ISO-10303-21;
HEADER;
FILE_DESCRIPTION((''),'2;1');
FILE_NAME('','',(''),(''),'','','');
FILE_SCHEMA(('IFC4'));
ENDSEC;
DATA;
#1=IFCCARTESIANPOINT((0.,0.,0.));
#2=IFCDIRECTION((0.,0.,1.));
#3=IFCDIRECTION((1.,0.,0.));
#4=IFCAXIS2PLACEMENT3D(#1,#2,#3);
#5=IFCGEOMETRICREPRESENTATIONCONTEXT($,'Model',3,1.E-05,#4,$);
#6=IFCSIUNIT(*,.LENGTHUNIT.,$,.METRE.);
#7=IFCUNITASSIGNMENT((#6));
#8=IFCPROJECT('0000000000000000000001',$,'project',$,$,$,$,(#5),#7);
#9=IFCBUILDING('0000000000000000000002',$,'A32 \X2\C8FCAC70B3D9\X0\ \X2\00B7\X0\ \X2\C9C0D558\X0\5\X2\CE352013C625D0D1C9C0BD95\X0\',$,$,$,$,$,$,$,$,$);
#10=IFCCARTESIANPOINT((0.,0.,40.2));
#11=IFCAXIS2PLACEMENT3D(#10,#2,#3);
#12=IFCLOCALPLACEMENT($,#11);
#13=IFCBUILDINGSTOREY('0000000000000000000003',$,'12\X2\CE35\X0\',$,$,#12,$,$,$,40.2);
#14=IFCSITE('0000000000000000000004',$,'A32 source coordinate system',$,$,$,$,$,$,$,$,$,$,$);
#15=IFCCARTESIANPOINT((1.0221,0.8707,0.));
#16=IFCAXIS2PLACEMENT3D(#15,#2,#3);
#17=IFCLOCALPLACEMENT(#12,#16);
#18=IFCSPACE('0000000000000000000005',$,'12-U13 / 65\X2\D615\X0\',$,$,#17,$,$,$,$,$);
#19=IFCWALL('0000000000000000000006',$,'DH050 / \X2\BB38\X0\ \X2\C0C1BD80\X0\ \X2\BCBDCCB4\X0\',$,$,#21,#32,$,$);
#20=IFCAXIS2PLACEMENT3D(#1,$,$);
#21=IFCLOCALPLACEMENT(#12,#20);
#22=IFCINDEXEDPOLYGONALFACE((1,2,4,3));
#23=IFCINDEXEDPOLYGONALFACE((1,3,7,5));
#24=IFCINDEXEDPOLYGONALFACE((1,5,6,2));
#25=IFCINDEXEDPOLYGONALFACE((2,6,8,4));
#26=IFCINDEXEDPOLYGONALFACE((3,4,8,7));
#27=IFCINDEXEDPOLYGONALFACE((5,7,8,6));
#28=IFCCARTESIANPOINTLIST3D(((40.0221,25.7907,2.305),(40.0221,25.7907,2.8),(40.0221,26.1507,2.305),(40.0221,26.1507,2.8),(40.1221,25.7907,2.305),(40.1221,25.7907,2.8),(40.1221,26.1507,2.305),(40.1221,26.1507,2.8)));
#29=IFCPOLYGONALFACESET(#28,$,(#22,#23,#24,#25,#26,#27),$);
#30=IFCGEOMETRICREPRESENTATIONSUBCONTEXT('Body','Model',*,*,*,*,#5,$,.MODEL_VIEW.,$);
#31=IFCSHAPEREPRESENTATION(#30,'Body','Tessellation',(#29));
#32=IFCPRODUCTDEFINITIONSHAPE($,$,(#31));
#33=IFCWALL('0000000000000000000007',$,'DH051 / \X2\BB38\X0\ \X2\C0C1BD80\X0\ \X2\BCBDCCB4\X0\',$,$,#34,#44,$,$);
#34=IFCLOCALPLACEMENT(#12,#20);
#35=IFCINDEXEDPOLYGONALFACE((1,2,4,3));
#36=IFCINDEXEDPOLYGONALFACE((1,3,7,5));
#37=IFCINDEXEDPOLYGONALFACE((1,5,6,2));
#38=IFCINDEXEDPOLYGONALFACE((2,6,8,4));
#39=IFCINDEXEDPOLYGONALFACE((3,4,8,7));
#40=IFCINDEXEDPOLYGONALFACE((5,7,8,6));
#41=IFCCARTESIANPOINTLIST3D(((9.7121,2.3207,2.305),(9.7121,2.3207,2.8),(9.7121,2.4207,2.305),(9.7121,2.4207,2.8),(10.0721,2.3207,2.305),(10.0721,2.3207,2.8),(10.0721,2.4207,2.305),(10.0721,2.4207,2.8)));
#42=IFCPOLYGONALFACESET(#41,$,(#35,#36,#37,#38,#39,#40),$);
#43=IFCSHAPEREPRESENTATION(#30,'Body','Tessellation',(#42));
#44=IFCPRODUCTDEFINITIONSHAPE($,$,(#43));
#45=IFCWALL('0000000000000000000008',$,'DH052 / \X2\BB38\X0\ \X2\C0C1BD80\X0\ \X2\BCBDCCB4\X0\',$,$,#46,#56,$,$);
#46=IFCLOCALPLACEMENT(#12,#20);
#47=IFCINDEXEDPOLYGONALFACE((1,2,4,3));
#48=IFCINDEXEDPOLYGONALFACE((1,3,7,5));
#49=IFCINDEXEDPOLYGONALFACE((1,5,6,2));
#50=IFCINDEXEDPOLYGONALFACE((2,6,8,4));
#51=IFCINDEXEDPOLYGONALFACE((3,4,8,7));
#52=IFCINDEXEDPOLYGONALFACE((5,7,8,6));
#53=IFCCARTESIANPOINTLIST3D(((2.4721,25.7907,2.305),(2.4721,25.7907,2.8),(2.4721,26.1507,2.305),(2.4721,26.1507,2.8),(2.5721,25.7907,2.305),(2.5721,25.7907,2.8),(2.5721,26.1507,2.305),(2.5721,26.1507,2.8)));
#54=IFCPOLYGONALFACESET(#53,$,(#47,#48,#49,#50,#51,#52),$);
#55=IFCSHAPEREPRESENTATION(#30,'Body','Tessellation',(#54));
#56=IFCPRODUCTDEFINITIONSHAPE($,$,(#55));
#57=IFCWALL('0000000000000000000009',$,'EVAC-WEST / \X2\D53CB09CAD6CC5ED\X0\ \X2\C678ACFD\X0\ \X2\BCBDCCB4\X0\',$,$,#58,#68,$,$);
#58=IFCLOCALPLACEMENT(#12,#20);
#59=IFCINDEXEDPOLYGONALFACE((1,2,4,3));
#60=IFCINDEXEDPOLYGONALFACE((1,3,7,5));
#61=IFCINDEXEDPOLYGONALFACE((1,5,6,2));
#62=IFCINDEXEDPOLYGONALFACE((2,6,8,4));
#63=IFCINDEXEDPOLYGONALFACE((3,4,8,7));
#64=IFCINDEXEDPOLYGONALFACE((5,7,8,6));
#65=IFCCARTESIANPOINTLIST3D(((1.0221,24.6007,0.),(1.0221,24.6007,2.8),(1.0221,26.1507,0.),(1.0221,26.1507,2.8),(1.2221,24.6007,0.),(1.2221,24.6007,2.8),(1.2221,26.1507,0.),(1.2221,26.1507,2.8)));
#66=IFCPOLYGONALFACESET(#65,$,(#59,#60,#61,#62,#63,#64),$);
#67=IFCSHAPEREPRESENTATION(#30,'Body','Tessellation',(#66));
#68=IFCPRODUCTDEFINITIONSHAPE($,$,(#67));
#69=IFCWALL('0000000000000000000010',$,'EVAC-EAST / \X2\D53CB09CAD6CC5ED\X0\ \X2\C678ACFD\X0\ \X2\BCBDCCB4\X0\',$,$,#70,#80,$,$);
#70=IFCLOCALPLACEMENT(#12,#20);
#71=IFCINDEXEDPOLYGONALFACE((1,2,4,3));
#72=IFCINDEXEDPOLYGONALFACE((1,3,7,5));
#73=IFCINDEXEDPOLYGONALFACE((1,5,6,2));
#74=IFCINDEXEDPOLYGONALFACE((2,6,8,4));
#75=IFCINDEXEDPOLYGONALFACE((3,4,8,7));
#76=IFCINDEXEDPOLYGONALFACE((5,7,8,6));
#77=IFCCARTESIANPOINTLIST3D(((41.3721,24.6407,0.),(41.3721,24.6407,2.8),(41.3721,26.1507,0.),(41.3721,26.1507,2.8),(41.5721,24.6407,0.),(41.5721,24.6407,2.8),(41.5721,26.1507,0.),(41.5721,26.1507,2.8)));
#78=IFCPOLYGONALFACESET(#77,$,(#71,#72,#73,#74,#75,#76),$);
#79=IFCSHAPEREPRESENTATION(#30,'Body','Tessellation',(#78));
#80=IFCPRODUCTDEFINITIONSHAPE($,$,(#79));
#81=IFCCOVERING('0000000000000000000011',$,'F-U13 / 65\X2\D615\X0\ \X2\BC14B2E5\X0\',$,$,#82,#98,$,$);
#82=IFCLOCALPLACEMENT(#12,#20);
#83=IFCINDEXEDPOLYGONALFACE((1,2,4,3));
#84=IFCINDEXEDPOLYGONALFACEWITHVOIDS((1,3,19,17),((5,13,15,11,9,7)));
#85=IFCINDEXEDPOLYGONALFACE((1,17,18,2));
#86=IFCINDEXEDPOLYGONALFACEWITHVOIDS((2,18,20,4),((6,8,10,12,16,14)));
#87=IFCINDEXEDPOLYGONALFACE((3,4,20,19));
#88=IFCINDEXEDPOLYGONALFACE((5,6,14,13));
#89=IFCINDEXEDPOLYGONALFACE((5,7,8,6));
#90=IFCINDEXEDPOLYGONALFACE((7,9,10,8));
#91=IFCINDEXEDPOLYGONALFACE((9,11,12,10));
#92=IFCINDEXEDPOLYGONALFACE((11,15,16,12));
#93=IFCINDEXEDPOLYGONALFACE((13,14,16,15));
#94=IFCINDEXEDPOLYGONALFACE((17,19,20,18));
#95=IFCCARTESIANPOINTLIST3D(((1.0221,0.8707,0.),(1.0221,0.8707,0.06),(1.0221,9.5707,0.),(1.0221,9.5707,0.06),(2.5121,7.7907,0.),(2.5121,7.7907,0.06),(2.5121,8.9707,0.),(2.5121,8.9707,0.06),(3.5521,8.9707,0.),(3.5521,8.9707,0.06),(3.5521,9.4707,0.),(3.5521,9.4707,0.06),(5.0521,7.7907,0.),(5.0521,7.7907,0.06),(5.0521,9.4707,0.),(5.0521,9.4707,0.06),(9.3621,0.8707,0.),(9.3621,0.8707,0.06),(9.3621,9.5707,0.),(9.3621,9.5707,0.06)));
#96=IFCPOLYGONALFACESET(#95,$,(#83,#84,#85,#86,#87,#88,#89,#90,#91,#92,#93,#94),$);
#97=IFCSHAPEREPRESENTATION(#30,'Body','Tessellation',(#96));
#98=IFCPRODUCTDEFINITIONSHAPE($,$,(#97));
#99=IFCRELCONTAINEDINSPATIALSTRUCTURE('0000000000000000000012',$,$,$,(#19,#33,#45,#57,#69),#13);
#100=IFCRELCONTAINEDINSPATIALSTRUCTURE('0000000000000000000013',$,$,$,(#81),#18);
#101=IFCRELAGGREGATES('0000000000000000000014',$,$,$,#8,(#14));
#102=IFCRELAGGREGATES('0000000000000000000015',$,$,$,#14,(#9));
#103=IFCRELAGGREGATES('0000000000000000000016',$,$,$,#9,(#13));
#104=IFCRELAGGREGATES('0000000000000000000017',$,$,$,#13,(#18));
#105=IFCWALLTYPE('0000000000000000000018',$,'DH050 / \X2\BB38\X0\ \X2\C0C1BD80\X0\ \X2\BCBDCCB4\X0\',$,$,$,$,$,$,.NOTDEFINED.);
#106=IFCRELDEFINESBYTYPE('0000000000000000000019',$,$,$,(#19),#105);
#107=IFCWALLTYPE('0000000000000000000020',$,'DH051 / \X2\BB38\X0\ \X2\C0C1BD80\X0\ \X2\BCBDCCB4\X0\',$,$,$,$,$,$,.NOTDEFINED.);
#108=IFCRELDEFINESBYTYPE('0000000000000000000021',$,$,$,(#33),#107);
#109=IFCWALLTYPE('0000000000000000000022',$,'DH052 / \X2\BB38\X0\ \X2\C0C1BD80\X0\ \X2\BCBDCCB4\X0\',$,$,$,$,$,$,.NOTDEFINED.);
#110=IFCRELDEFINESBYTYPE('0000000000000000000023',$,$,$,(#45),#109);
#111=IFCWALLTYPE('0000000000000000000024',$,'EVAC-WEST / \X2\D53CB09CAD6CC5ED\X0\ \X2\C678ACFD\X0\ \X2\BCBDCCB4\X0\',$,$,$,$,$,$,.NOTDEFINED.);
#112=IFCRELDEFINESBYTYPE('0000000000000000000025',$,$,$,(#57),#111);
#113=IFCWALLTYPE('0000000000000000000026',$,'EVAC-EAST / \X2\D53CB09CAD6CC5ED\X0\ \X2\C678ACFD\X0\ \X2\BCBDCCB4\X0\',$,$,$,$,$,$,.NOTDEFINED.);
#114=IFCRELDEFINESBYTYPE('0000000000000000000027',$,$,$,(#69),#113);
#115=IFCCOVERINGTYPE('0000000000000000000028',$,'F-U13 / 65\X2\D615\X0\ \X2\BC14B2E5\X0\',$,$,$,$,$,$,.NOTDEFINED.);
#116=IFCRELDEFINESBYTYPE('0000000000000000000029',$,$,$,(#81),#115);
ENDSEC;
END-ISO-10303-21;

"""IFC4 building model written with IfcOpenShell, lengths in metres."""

from ifc_helpers import new_model, si_unit, frame, origin, origin_with_axes, place, context, subcontext, project, spatial, polyline, outline, extrude, source, transform, mapped, type_object, type_shapes, element, save


model = new_model("IFC4")

# Units and contexts
model_context = context("Model", 3, precision=1e-05, world=origin_with_axes())
body_context = subcontext(model_context, "Body", "Model", "MODEL_VIEW")
ifc_project = project(units=[si_unit("LENGTHUNIT", "METRE")], contexts=[model_context])

# Site, building, storey
site = spatial("IfcSite", under=ifc_project, Name="A32 source coordinate system")
building = spatial("IfcBuilding", under=site, Name="A32 주거동 · 지하5층–옥탑지붕")
storey_placement = place(None, frame((0.0, 0.0, 40.2), z_axis=(0.0, 0.0, 1.0), x_axis=(1.0, 0.0, 0.0)))
storey = spatial("IfcBuildingStorey", under=building, at=storey_placement, Name="12층", Elevation=40.2)

# Walls
wall_type_1 = type_object("IfcWallType", Name="DH050 / 문 상부 벽체", PredefinedType="NOTDEFINED")
shared_shape_1 = source(origin(), body_context, "Body", "SweptSolid", [
    extrude(outline(polyline([(40.0221, 25.7907), (40.0221, 26.1507), (40.1221, 26.1507), (40.1221, 25.7907), (40.0221, 25.7907)])), frame((0.0, 0.0, 2.305)), (0.0, 0.0, 1.0), 0.495),
])
type_shapes(wall_type_1, [shared_shape_1])
wall_1_placement = place(storey_placement, origin_with_axes())
element("IfcWall", 1, at=wall_1_placement, inside=storey, type_object=wall_type_1, Name="DH050 / 문 상부 벽체", context=body_context, shape_type="MappedRepresentation", body=[
    mapped(shared_shape_1, transform((0.0, 0.0, 0.0), scale=1.0)),
])
wall_type_2 = type_object("IfcWallType", Name="DH051 / 문 상부 벽체", PredefinedType="NOTDEFINED")
shared_shape_2 = source(origin(), body_context, "Body", "SweptSolid", [
    extrude(outline(polyline([(10.0721, 2.3207), (9.7121, 2.3207), (9.7121, 2.4207), (10.0721, 2.4207), (10.0721, 2.3207)])), frame((0.0, 0.0, 2.305)), (0.0, 0.0, 1.0), 0.495),
])
type_shapes(wall_type_2, [shared_shape_2])
wall_2_placement = place(storey_placement, origin_with_axes())
element("IfcWall", 2, at=wall_2_placement, inside=storey, type_object=wall_type_2, Name="DH051 / 문 상부 벽체", context=body_context, shape_type="MappedRepresentation", body=[
    mapped(shared_shape_2, transform((0.0, 0.0, 0.0), scale=1.0)),
])
wall_type_3 = type_object("IfcWallType", Name="DH052 / 문 상부 벽체", PredefinedType="NOTDEFINED")
shared_shape_3 = source(origin(), body_context, "Body", "SweptSolid", [
    extrude(outline(polyline([(2.5721, 25.7907), (2.4721, 25.7907), (2.4721, 26.1507), (2.5721, 26.1507), (2.5721, 25.7907)])), frame((0.0, 0.0, 2.305)), (0.0, 0.0, 1.0), 0.495),
])
type_shapes(wall_type_3, [shared_shape_3])
wall_3_placement = place(storey_placement, origin_with_axes())
element("IfcWall", 3, at=wall_3_placement, inside=storey, type_object=wall_type_3, Name="DH052 / 문 상부 벽체", context=body_context, shape_type="MappedRepresentation", body=[
    mapped(shared_shape_3, transform((0.0, 0.0, 0.0), scale=1.0)),
])
wall_type_4 = type_object("IfcWallType", Name="EVAC-WEST / 피난구역 외곽 벽체", PredefinedType="NOTDEFINED")
shared_shape_4 = source(origin(), body_context, "Body", "SweptSolid", [
    extrude(outline(polyline([(1.2221, 24.6007), (1.0221, 24.6007), (1.0221, 26.1507), (1.2221, 26.1507), (1.2221, 24.6007)])), origin(), (0.0, 0.0, 1.0), 2.8),
])
type_shapes(wall_type_4, [shared_shape_4])
wall_4_placement = place(storey_placement, origin_with_axes())
element("IfcWall", 4, at=wall_4_placement, inside=storey, type_object=wall_type_4, Name="EVAC-WEST / 피난구역 외곽 벽체", context=body_context, shape_type="MappedRepresentation", body=[
    mapped(shared_shape_4, transform((0.0, 0.0, 0.0), scale=1.0)),
])
wall_type_5 = type_object("IfcWallType", Name="EVAC-EAST / 피난구역 외곽 벽체", PredefinedType="NOTDEFINED")
shared_shape_5 = source(origin(), body_context, "Body", "SweptSolid", [
    extrude(outline(polyline([(41.5721, 26.1507), (41.5721, 24.6407), (41.3721, 24.6407), (41.3721, 26.1507), (41.5721, 26.1507)])), origin(), (0.0, 0.0, 1.0), 2.8),
])
type_shapes(wall_type_5, [shared_shape_5])
wall_5_placement = place(storey_placement, origin_with_axes())
element("IfcWall", 5, at=wall_5_placement, inside=storey, type_object=wall_type_5, Name="EVAC-EAST / 피난구역 외곽 벽체", context=body_context, shape_type="MappedRepresentation", body=[
    mapped(shared_shape_5, transform((0.0, 0.0, 0.0), scale=1.0)),
])

# Shared definitions
space_placement = place(storey_placement, frame((1.0221, 0.8707, 0.0), z_axis=(0.0, 0.0, 1.0), x_axis=(1.0, 0.0, 0.0)))
space = spatial("IfcSpace", under=storey, at=space_placement, Name="12-U13 / 65형")

# Covering
covering_type_1 = type_object("IfcCoveringType", Name="F-U13 / 65형 바닥", PredefinedType="NOTDEFINED")
shared_shape_6 = source(origin(), body_context, "Body", "SweptSolid", [
    extrude(outline(polyline([(0.0, 0.0), (0.0, 8.7), (8.34, 8.7), (8.34, 0.0), (0.0, 0.0)]), holes=[polyline([(2.53, 8.1), (1.49, 8.1), (1.49, 6.92), (4.03, 6.92), (4.03, 8.6), (2.53, 8.6), (2.53, 8.1)])]), origin(), (0.0, 0.0, 1.0), 0.06),
])
type_shapes(covering_type_1, [shared_shape_6])
covering_1_placement = place(space_placement, origin_with_axes())
element("IfcCovering", 6, at=covering_1_placement, inside=space, type_object=covering_type_1, Name="F-U13 / 65형 바닥", context=body_context, shape_type="MappedRepresentation", body=[
    mapped(shared_shape_6, transform((0.0, 0.0, 0.0), scale=1.0)),
])

save(model, "model.ifc")
